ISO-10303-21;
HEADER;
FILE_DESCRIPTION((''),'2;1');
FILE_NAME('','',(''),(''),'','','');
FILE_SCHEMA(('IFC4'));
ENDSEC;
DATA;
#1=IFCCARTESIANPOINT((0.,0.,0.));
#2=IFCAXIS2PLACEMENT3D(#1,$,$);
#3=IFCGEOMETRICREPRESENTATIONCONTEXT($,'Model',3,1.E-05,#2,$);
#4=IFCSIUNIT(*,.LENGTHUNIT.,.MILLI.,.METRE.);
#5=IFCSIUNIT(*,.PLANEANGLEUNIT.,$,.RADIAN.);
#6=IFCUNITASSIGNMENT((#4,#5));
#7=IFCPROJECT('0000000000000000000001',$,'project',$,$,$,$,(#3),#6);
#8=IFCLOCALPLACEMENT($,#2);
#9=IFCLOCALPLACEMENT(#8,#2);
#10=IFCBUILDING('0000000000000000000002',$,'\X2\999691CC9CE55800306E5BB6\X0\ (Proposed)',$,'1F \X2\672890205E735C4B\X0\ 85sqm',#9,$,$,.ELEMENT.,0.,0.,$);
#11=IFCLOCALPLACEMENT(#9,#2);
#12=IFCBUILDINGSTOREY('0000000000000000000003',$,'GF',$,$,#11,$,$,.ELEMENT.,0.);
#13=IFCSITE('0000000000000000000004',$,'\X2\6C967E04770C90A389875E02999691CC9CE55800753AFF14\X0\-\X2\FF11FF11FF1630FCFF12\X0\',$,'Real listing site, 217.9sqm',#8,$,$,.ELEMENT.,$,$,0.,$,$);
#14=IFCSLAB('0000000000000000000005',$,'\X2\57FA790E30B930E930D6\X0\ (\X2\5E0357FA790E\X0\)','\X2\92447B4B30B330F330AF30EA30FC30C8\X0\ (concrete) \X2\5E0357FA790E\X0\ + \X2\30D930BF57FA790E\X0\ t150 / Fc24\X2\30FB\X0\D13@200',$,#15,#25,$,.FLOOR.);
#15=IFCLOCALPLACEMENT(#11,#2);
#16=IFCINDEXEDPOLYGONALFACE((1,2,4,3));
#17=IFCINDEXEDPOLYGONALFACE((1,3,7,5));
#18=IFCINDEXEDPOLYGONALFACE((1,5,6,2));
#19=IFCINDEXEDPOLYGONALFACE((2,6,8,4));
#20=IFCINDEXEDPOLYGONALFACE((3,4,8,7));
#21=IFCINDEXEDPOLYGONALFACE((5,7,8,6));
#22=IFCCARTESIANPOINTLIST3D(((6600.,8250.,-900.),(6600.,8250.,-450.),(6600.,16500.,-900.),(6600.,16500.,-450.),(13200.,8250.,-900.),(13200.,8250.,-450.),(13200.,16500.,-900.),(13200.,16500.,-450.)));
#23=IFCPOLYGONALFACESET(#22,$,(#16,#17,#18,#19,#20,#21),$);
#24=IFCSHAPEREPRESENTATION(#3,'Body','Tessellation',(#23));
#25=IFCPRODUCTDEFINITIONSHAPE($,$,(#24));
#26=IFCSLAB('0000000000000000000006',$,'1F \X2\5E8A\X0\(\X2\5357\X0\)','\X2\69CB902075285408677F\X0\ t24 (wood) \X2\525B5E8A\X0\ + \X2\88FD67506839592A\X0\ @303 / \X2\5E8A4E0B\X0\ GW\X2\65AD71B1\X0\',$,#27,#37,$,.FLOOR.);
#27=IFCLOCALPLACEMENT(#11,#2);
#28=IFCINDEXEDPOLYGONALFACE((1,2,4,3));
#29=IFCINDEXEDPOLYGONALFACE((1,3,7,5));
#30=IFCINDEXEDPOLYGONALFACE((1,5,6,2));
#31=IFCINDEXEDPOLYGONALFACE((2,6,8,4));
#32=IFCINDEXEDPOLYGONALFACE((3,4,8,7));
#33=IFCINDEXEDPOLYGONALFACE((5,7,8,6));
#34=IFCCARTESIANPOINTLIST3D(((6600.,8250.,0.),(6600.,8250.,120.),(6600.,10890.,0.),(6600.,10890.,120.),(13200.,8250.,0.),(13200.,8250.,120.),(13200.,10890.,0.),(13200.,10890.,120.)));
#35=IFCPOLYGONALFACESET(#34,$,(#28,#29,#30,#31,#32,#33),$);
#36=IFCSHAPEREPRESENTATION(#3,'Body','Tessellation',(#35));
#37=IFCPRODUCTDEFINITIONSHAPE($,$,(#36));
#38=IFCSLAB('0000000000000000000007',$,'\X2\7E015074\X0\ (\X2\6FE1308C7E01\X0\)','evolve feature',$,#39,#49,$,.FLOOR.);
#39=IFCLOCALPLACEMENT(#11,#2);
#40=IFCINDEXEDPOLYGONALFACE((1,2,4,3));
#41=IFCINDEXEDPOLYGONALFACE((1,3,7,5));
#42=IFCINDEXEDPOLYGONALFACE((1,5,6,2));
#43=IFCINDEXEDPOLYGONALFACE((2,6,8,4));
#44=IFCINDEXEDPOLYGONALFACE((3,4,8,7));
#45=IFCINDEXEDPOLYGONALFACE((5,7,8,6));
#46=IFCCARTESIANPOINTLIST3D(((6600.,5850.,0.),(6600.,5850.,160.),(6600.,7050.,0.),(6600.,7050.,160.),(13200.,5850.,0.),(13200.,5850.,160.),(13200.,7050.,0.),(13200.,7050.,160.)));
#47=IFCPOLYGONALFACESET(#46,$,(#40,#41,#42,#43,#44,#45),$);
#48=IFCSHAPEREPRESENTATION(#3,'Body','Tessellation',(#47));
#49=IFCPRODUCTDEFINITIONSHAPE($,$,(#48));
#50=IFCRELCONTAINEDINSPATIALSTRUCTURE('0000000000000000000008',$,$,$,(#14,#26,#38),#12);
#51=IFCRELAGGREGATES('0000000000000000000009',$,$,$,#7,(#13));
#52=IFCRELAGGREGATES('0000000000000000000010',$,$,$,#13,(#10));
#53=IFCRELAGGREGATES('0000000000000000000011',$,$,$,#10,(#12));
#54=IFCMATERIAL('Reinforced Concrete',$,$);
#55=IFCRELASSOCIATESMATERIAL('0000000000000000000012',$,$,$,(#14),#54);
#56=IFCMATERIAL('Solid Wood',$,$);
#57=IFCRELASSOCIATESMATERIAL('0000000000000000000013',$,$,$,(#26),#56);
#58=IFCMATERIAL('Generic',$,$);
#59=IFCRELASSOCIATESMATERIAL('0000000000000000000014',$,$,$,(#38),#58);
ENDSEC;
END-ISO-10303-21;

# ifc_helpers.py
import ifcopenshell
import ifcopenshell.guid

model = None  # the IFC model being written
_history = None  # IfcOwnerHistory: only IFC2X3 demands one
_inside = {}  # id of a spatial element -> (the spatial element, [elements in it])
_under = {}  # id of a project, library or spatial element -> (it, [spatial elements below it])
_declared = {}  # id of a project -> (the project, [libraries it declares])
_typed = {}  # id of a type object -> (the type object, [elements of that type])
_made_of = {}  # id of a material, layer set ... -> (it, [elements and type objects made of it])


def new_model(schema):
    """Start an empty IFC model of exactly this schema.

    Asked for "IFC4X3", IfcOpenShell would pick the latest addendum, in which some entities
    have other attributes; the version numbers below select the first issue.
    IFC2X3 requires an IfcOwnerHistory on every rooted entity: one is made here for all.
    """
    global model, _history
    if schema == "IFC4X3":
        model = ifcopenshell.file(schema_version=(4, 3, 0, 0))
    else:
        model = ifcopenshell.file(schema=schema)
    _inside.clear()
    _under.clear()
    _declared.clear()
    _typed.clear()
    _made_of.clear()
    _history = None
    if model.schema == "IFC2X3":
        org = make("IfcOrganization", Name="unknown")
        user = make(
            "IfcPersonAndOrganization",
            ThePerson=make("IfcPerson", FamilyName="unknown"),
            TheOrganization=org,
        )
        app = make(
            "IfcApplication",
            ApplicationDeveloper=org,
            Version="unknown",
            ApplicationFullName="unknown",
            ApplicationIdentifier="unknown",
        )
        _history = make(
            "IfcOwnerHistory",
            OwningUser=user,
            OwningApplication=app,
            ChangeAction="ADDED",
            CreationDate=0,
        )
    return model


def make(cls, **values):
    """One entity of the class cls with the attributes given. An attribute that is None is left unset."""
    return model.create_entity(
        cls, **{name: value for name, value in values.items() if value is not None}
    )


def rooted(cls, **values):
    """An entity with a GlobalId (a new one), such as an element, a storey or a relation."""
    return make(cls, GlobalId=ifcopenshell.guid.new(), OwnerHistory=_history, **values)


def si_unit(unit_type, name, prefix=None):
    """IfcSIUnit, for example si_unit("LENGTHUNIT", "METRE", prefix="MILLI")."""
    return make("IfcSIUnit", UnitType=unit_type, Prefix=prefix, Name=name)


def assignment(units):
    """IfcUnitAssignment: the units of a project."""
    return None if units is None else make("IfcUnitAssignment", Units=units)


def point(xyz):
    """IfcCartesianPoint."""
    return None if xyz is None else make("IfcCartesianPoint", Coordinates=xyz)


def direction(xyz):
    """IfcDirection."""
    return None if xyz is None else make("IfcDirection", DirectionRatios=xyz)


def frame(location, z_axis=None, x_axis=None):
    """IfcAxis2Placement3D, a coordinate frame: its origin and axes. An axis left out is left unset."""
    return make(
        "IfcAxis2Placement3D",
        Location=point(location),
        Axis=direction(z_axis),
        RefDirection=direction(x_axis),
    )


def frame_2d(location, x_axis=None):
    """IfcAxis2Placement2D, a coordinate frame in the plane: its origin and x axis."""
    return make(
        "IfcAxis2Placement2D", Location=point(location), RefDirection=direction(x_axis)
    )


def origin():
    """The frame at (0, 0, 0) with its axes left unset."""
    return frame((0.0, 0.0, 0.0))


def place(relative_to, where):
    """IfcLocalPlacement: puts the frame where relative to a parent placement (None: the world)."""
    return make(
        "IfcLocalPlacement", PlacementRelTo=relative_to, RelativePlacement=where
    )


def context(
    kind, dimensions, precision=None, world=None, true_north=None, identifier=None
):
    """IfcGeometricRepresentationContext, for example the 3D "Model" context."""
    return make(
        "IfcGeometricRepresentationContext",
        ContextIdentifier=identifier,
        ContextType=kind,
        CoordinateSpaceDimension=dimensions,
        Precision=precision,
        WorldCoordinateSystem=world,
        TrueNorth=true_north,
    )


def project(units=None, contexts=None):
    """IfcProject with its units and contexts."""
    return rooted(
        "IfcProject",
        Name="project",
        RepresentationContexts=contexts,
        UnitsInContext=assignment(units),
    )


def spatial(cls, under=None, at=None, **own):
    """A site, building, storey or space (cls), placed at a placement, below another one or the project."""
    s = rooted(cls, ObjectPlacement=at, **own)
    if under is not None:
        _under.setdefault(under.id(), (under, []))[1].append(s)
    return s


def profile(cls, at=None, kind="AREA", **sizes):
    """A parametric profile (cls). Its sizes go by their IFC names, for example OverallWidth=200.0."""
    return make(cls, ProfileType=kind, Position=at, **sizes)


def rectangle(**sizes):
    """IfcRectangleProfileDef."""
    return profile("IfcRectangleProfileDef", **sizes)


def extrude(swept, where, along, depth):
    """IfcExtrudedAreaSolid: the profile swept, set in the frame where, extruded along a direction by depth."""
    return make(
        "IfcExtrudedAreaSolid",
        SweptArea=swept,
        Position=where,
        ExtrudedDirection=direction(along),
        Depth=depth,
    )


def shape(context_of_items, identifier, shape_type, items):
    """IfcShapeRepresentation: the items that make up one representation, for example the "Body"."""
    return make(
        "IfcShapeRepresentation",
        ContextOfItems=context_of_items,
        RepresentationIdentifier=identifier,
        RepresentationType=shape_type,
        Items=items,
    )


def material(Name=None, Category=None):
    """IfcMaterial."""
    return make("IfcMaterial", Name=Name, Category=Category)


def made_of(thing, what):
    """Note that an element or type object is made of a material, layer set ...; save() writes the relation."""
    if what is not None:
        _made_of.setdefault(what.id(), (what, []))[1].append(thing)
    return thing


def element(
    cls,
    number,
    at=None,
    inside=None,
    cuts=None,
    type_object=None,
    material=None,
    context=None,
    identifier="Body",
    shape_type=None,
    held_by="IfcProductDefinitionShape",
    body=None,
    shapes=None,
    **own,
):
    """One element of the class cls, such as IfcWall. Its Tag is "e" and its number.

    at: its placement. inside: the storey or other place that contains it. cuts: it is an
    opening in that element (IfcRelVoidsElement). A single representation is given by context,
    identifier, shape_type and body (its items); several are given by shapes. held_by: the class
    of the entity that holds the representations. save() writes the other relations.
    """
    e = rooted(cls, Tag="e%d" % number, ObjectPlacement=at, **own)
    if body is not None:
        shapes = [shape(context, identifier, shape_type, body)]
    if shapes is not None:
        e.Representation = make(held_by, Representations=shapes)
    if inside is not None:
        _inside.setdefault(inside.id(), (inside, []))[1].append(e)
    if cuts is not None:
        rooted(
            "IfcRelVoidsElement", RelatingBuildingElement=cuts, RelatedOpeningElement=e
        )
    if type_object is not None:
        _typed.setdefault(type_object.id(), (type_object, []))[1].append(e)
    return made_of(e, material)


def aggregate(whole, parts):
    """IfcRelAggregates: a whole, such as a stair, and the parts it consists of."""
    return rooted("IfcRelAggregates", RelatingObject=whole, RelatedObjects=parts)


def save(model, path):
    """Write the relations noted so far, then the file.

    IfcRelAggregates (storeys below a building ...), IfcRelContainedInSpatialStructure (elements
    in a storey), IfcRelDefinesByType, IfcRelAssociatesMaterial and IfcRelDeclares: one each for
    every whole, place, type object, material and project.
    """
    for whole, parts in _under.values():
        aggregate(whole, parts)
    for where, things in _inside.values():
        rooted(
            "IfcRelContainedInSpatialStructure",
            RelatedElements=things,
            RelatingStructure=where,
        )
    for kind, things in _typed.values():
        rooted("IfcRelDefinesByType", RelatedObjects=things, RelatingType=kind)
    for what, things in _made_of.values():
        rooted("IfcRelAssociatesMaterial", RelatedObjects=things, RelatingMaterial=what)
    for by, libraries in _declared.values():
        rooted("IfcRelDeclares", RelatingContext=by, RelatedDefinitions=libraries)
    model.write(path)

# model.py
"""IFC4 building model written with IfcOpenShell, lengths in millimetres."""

from ifc_helpers import new_model, si_unit, frame, frame_2d, origin, place, context, project, spatial, rectangle, extrude, material, element, save


model = new_model("IFC4")

# Units and contexts
model_context = context("Model", 3, precision=1e-05, world=origin())
ifc_project = project(units=[si_unit("LENGTHUNIT", "METRE", prefix="MILLI"), si_unit("PLANEANGLEUNIT", "RADIAN")], contexts=[model_context])

# Site, building, storey
site_placement = place(None, origin())
site = spatial("IfcSite", under=ifc_project, at=site_placement, Name="沖縄県那覇市首里鳥堀町４-１１６ー２", ObjectType="Real listing site, 217.9sqm", CompositionType="ELEMENT", RefElevation=0.0)
building_placement = place(site_placement, origin())
building = spatial("IfcBuilding", under=site, at=building_placement, Name="首里鳥堀の家 (Proposed)", ObjectType="1F 木造平屋 85sqm", CompositionType="ELEMENT", ElevationOfRefHeight=0.0, ElevationOfTerrain=0.0)
storey_placement = place(building_placement, origin())
storey = spatial("IfcBuildingStorey", under=building, at=storey_placement, Name="GF", CompositionType="ELEMENT", Elevation=0.0)

# Slabs
ifc_material_1 = material(Name="Reinforced Concrete")
slab_1_placement = place(storey_placement, frame((3300.0, 4125.0, -450.0)))
element("IfcSlab", 1, at=slab_1_placement, inside=storey, material=ifc_material_1, Name="基礎スラブ (布基礎)", Description="鉄筋コンクリート (concrete) 布基礎 + ベタ基礎 t150 / Fc24・D13@200", PredefinedType="FLOOR", context=model_context, shape_type="SweptSolid", body=[
    extrude(rectangle(XDim=6600.0, YDim=8250.0, at=frame_2d((3300.0, 4125.0))), frame((3300.0, 4125.0, -450.0)), (0.0, 0.0, 1.0), 450.0),
])
ifc_material_2 = material(Name="Solid Wood")
slab_2_placement = place(storey_placement, frame((3300.0, 4125.0, 0.0)))
element("IfcSlab", 2, at=slab_2_placement, inside=storey, material=ifc_material_2, Name="1F 床(南)", Description="構造用合板 t24 (wood) 剛床 + 製材根太 @303 / 床下 GW断熱", PredefinedType="FLOOR", context=model_context, shape_type="SweptSolid", body=[
    extrude(rectangle(XDim=6600.0, YDim=2640.0, at=frame_2d((3300.0, 1320.0))), frame((3300.0, 4125.0, 0.0)), (0.0, 0.0, 1.0), 120.0),
])
ifc_material_3 = material(Name="Generic")
slab_3_placement = place(storey_placement, frame((3300.0, 2925.0, 0.0)))
element("IfcSlab", 3, at=slab_3_placement, inside=storey, material=ifc_material_3, Name="縁側 (濡れ縁)", Description="evolve feature", PredefinedType="FLOOR", context=model_context, shape_type="SweptSolid", body=[
    extrude(rectangle(XDim=6600.0, YDim=1200.0, at=frame_2d((3300.0, 600.0))), frame((3300.0, 2925.0, 0.0)), (0.0, 0.0, 1.0), 160.0),
])

save(model, "model.ifc")
